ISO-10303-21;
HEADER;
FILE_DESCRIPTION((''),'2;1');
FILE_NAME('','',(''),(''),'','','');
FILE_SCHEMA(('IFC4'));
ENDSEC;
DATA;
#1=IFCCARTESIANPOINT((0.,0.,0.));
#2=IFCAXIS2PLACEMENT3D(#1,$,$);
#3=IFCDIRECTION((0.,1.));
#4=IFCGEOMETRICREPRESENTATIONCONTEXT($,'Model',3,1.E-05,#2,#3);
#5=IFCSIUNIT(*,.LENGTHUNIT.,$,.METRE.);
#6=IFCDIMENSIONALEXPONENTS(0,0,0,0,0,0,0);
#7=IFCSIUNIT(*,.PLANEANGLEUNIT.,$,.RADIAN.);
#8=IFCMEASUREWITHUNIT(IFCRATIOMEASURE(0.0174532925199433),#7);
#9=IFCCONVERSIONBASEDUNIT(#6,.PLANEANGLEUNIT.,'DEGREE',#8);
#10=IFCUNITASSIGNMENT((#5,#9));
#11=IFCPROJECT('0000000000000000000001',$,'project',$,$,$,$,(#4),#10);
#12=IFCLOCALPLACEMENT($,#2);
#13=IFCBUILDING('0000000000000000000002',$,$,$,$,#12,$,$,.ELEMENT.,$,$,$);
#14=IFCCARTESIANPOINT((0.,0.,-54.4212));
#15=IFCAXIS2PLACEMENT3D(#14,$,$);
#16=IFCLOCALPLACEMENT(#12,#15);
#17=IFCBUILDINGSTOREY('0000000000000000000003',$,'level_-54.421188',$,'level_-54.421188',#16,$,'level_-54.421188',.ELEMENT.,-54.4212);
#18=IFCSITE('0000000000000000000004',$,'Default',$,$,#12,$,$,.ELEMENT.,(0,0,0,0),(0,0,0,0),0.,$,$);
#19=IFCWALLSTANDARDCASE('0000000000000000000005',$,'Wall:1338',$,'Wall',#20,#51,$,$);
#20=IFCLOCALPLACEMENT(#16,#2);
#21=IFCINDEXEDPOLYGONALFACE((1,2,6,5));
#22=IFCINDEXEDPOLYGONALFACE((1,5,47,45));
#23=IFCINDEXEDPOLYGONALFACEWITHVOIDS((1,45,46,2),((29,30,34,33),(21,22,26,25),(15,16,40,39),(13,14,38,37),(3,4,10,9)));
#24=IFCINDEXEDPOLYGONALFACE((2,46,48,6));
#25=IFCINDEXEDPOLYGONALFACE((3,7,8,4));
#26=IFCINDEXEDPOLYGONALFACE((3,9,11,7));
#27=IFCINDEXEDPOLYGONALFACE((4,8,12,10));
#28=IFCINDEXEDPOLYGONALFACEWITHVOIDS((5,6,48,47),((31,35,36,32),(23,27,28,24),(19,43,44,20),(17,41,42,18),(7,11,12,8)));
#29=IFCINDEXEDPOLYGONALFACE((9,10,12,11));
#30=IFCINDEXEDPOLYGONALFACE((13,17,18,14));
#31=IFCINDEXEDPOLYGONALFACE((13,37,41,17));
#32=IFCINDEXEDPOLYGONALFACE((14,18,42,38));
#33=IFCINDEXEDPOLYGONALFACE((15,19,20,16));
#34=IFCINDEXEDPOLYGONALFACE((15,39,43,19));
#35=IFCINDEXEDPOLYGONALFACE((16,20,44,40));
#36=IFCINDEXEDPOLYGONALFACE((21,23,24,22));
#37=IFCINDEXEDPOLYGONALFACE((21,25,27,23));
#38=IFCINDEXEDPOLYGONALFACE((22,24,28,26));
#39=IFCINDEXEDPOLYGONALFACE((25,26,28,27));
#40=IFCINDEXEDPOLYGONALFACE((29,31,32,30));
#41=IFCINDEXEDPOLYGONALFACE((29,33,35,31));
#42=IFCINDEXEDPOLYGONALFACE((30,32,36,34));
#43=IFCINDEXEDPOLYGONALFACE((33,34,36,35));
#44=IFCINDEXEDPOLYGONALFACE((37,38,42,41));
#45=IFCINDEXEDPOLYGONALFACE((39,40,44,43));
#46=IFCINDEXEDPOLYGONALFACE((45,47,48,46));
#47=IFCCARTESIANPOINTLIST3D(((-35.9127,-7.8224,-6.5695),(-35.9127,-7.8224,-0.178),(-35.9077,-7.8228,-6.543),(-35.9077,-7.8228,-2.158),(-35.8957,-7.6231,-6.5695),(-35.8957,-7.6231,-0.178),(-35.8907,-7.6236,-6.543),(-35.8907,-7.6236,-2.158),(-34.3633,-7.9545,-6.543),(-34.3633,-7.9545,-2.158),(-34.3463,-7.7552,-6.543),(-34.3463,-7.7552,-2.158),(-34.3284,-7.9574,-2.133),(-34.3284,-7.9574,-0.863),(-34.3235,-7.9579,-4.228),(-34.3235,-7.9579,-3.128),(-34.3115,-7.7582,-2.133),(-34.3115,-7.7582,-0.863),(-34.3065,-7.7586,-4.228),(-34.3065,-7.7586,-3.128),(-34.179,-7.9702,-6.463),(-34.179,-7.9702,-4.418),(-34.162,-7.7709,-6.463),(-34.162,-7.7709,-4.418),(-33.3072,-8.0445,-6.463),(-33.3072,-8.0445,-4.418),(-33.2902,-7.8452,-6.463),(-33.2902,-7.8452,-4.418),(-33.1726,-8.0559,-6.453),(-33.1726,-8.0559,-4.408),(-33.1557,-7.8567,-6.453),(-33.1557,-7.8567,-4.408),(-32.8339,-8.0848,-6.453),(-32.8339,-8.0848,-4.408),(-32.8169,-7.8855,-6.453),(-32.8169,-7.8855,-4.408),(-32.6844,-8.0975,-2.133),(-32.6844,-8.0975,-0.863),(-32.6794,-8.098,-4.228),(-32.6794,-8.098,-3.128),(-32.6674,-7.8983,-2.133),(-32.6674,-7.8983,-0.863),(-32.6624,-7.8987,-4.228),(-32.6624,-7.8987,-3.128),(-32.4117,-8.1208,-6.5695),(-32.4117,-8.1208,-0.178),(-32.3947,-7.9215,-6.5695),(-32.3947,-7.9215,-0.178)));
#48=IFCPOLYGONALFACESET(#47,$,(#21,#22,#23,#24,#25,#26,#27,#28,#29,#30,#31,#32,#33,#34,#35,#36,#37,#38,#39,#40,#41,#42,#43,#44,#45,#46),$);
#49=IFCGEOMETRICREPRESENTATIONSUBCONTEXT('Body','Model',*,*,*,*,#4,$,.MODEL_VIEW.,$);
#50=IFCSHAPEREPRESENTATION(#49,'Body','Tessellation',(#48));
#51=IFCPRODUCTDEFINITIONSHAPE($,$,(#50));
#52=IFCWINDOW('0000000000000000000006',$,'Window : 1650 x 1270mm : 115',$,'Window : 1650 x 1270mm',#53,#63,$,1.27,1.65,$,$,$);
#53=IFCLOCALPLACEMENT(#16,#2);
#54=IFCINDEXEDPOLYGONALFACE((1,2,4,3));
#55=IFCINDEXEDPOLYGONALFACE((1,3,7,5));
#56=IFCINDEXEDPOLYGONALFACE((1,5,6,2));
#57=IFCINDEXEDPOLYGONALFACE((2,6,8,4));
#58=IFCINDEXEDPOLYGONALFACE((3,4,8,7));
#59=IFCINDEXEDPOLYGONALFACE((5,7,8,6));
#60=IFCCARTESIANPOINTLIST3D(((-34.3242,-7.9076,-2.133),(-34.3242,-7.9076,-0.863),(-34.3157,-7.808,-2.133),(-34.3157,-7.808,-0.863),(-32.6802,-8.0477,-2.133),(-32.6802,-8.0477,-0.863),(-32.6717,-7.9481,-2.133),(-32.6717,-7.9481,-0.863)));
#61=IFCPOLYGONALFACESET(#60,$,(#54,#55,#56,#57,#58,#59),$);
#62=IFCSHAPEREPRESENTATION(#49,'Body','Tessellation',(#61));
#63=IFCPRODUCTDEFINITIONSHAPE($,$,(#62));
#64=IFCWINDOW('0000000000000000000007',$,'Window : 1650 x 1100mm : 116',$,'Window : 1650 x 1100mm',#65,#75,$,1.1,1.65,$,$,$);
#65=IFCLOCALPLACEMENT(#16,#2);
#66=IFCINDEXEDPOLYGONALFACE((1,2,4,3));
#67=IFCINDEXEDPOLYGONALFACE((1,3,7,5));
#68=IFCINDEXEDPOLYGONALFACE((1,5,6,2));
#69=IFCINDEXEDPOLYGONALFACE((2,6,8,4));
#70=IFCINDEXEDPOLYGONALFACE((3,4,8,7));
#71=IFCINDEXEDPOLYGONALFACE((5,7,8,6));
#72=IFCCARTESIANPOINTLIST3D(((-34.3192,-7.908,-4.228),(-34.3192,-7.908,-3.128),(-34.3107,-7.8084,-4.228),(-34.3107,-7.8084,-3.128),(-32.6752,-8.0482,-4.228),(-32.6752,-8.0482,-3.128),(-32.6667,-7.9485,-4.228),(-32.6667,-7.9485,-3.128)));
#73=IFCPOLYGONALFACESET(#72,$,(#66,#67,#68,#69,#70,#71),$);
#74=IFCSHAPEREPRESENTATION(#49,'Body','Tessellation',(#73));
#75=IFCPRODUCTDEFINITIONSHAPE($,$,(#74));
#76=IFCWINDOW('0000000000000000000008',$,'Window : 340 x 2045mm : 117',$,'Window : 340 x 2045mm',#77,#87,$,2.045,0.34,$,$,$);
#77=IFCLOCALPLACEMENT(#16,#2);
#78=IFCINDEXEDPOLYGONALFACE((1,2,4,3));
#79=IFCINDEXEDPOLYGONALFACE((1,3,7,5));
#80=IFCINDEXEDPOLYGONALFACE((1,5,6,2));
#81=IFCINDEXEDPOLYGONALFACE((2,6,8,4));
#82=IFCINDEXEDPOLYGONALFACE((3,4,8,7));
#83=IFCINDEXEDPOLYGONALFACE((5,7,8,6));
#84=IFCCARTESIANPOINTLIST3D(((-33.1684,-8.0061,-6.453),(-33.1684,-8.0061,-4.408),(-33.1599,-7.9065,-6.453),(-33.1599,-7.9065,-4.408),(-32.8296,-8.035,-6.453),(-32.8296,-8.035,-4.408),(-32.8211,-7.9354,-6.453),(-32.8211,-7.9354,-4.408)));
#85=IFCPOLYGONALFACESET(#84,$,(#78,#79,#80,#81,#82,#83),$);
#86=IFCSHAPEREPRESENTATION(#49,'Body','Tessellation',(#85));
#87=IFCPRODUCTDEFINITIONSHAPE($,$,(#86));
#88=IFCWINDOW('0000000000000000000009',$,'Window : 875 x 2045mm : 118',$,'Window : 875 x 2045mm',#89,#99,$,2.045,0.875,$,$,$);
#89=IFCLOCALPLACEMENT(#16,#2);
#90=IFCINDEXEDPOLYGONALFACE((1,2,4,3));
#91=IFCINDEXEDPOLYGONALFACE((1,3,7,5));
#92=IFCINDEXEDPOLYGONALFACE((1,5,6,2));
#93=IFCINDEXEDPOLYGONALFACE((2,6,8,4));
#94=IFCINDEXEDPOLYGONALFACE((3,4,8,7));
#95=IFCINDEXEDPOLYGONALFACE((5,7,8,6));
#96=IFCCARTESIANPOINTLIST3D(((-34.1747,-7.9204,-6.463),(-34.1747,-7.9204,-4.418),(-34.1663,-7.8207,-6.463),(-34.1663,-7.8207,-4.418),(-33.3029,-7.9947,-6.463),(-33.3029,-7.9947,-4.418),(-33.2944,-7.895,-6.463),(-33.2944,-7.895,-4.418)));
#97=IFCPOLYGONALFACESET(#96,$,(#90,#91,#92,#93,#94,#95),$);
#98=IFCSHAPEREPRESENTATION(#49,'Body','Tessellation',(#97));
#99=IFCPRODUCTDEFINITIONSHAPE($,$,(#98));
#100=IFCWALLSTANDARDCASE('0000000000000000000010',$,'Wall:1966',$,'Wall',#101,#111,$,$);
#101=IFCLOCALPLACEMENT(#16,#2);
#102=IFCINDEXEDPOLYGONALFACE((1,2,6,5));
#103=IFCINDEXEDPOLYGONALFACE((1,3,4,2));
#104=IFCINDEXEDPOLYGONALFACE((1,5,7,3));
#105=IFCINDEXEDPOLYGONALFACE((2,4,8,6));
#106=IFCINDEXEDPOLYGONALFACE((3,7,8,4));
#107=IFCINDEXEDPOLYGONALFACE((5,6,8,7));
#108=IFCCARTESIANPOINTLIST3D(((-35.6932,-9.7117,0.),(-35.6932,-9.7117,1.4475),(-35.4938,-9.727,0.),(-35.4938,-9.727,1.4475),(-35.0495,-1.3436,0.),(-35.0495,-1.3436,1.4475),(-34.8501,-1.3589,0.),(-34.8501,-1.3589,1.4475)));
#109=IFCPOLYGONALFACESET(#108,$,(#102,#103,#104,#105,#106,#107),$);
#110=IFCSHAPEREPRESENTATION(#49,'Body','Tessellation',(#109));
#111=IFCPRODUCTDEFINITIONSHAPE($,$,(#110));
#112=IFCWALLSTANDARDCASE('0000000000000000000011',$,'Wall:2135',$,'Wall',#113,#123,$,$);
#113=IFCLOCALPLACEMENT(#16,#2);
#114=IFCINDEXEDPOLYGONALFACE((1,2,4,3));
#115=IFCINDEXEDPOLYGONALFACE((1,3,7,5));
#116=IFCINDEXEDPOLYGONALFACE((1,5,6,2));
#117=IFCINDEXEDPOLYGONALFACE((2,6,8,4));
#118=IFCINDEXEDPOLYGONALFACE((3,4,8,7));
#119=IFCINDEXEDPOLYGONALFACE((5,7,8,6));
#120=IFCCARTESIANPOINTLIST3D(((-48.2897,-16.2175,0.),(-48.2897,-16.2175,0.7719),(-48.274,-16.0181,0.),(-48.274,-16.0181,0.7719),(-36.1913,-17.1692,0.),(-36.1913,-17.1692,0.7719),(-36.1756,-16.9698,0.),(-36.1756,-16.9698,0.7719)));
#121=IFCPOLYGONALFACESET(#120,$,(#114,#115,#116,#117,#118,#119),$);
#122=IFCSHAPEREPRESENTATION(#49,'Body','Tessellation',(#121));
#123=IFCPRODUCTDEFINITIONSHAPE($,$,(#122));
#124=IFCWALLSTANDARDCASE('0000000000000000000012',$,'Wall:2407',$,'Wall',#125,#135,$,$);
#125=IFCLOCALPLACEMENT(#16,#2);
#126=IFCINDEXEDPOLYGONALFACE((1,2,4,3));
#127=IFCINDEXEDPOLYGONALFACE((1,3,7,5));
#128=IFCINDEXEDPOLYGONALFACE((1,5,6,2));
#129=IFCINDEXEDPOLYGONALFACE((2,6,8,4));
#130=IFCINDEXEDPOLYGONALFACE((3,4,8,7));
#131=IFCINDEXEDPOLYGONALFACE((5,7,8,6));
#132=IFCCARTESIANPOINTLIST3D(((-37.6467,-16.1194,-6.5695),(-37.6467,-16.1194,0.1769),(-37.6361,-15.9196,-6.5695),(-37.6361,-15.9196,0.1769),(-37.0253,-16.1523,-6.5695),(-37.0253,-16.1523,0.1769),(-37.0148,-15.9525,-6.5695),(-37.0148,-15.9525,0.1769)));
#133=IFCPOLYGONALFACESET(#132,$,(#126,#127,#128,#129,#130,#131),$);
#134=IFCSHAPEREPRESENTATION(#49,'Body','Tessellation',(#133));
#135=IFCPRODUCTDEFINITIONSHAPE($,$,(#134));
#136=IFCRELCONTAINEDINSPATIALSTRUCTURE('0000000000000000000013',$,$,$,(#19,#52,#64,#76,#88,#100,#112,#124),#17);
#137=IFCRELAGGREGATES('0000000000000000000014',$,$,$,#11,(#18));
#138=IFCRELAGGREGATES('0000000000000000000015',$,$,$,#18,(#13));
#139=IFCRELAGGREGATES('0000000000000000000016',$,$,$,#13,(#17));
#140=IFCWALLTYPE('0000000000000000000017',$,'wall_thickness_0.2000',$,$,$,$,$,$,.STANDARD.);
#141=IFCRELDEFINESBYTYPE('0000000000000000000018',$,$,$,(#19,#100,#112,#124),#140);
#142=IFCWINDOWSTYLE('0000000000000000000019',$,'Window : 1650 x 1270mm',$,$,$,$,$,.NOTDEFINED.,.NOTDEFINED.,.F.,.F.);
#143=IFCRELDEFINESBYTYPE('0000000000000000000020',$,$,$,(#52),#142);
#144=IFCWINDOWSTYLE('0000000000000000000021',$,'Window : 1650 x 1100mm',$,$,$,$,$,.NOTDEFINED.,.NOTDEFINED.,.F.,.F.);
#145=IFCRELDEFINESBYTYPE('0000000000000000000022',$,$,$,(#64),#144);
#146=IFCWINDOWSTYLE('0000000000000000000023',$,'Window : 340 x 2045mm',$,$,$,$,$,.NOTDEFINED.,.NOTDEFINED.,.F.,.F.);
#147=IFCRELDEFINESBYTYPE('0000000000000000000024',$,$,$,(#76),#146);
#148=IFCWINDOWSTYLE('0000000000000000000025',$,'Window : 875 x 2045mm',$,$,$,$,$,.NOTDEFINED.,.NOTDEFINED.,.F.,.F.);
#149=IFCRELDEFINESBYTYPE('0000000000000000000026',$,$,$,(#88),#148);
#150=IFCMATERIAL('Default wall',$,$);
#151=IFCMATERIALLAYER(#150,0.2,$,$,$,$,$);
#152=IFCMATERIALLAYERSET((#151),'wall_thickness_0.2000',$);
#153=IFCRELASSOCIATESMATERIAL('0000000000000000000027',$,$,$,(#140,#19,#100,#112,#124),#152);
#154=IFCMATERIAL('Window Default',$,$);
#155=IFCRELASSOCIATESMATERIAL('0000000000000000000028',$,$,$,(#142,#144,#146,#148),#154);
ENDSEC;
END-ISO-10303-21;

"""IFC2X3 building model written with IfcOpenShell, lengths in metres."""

from ifc_helpers import new_model, entity, si_unit, converted_unit, direction, frame, frame_2d, origin, origin_2d_with_axis, place, context, subcontext, project, spatial, polyline, rectangle, outline, extrude, source, transform, mapped, material, layer, layer_set, layer_usage, type_object, type_shapes, element, fill, save


model = new_model("IFC2X3")

# Units and contexts
model_context = context("Model", 3, precision=1e-05, world=origin(), true_north=direction((0.0, 1.0)))
body_context = subcontext(model_context, "Body", "Model", "MODEL_VIEW")
ifc_project = project(units=[si_unit("LENGTHUNIT", "METRE"), converted_unit("PLANEANGLEUNIT", "DEGREE", entity("IfcRatioMeasure", 0.0174532925199433), si_unit("PLANEANGLEUNIT", "RADIAN"), dimensions=[0, 0, 0, 0, 0, 0, 0])], contexts=[model_context])

# Site, building, storey
placement_1 = place(None, origin())
site = spatial("IfcSite", under=ifc_project, at=placement_1, Name="Default", CompositionType="ELEMENT", RefLatitude=(0, 0, 0, 0), RefLongitude=(0, 0, 0, 0), RefElevation=0.0)
building = spatial("IfcBuilding", under=site, at=placement_1, CompositionType="ELEMENT")
storey_placement = place(placement_1, frame((0.0, 0.0, -54.4212)))
storey = spatial("IfcBuildingStorey", under=building, at=storey_placement, Name="level_-54.421188", ObjectType="level_-54.421188", LongName="level_-54.421188", CompositionType="ELEMENT", Elevation=-54.4212)

# Shared definitions
ifc_material_1 = material(Name="Default wall")
ifc_layer = layer(ifc_material_1, 0.2)
ifc_layer_set = layer_set([ifc_layer], Name="wall_thickness_0.2000")
ifc_layer_usage = layer_usage(ifc_layer_set, "AXIS2", "POSITIVE", -0.1)
wall_type = type_object("IfcWallType", Name="wall_thickness_0.2000", PredefinedType="STANDARD", material=ifc_layer_set)

# Wall, openings, windows
ifc_material_2 = material(Name="Window Default")
placement_2 = place(placement_1, frame((0.0, 0.0, -60.9907)))
wall_1_placement = place(placement_2, frame((-32.4032, -8.0212, 0.0), z_axis=(0.0, 0.0, 1.0), x_axis=(-0.996388, 0.084916, 0.0)))
wall_1 = element("IfcWallStandardCase", 1, at=wall_1_placement, inside=storey, type_object=wall_type, material=ifc_layer_usage, Name="Wall:1338", ObjectType="Wall", context=body_context, shape_type="SweptSolid", body=[
    extrude(outline(polyline([(3.5137, -0.1), (3.5137, 0.1), (0.0, 0.1), (0.0, -0.1), (3.5137, -0.1)])), origin(), (0.0, 0.0, 1.0), 6.3915),
])
opening_1_placement = place(wall_1_placement, frame((1.9587, -0.1, 0.0265)))
element("IfcOpeningElement", 2, at=opening_1_placement, cuts=wall_1, ObjectType="Opening", context=body_context, shape_type="SweptSolid", body=[
    extrude(rectangle(XDim=1.55, YDim=4.385, at=frame_2d((2.1925, 0.775), x_axis=(0.0, 1.0))), frame((0.0, 0.0, 0.0), z_axis=(0.0, 1.0, 0.0), x_axis=(0.0, 0.0, 1.0)), (0.0, 0.0, 1.0), 0.2),
])
opening_2_placement = place(wall_1_placement, frame((0.2737, -0.1, 4.4365)))
opening_2 = element("IfcOpeningElement", 3, at=opening_2_placement, cuts=wall_1, ObjectType="Opening", context=body_context, shape_type="SweptSolid", body=[
    extrude(rectangle(XDim=1.65, YDim=1.27, at=frame_2d((0.635, 0.825), x_axis=(0.0, 1.0))), frame((0.0, 0.0, 0.0), z_axis=(0.0, 1.0, 0.0), x_axis=(0.0, 0.0, 1.0)), (0.0, 0.0, 1.0), 0.2),
])
opening_3_placement = place(wall_1_placement, frame((0.2687, -0.1, 2.3415)))
opening_3 = element("IfcOpeningElement", 4, at=opening_3_placement, cuts=wall_1, ObjectType="Opening", context=body_context, shape_type="SweptSolid", body=[
    extrude(rectangle(XDim=1.65, YDim=1.1, at=frame_2d((0.55, 0.825), x_axis=(0.0, 1.0))), frame((0.0, 0.0, 0.0), z_axis=(0.0, 1.0, 0.0), x_axis=(0.0, 0.0, 1.0)), (0.0, 0.0, 1.0), 0.2),
])
opening_4_placement = place(wall_1_placement, frame((0.4237, -0.1, 0.1165)))
opening_4 = element("IfcOpeningElement", 5, at=opening_4_placement, cuts=wall_1, ObjectType="Opening", context=body_context, shape_type="SweptSolid", body=[
    extrude(rectangle(XDim=0.34, YDim=2.045, at=frame_2d((1.0225, 0.17), x_axis=(0.0, 1.0))), frame((0.0, 0.0, 0.0), z_axis=(0.0, 1.0, 0.0), x_axis=(0.0, 0.0, 1.0)), (0.0, 0.0, 1.0), 0.2),
])
opening_5_placement = place(wall_1_placement, frame((0.8987, -0.1, 0.1065)))
opening_5 = element("IfcOpeningElement", 6, at=opening_5_placement, cuts=wall_1, ObjectType="Opening", context=body_context, shape_type="SweptSolid", body=[
    extrude(rectangle(XDim=0.875, YDim=2.045, at=frame_2d((1.0225, 0.4375), x_axis=(0.0, 1.0))), frame((0.0, 0.0, 0.0), z_axis=(0.0, 1.0, 0.0), x_axis=(0.0, 0.0, 1.0)), (0.0, 0.0, 1.0), 0.2),
])
window_style_1 = type_object("IfcWindowStyle", Name="Window : 1650 x 1270mm", ConstructionType="NOTDEFINED", OperationType="NOTDEFINED", ParameterTakesPrecedence=False, Sizeable=False, material=ifc_material_2)
shared_shape_1 = source(origin(), body_context, "Body", "SweptSolid", [
    extrude(rectangle(XDim=0.1, YDim=1.65, at=origin_2d_with_axis()), frame((0.825, 0.1, 0.0), z_axis=(0.0, 0.0, 1.0), x_axis=(0.0, 1.0, 0.0)), (0.0, 0.0, 1.0), 1.27),
])
type_shapes(window_style_1, [shared_shape_1])
window_1_placement = place(opening_2_placement, origin())
window_1 = element("IfcWindow", 7, at=window_1_placement, inside=storey, type_object=window_style_1, Name="Window : 1650 x 1270mm : 115", ObjectType="Window : 1650 x 1270mm", OverallHeight=1.27, OverallWidth=1.65, context=body_context, shape_type="MappedRepresentation", body=[
    mapped(shared_shape_1, transform((0.0, 0.0, 0.0), scale=1.0)),
])
fill(opening_2, window_1)
window_style_2 = type_object("IfcWindowStyle", Name="Window : 1650 x 1100mm", ConstructionType="NOTDEFINED", OperationType="NOTDEFINED", ParameterTakesPrecedence=False, Sizeable=False, material=ifc_material_2)
shared_shape_2 = source(origin(), body_context, "Body", "SweptSolid", [
    extrude(rectangle(XDim=0.1, YDim=1.65, at=origin_2d_with_axis()), frame((0.825, 0.1, 0.0), z_axis=(0.0, 0.0, 1.0), x_axis=(0.0, 1.0, 0.0)), (0.0, 0.0, 1.0), 1.1),
])
type_shapes(window_style_2, [shared_shape_2])
window_2_placement = place(opening_3_placement, origin())
window_2 = element("IfcWindow", 8, at=window_2_placement, inside=storey, type_object=window_style_2, Name="Window : 1650 x 1100mm : 116", ObjectType="Window : 1650 x 1100mm", OverallHeight=1.1, OverallWidth=1.65, context=body_context, shape_type="MappedRepresentation", body=[
    mapped(shared_shape_2, transform((0.0, 0.0, 0.0), scale=1.0)),
])
fill(opening_3, window_2)
window_style_3 = type_object("IfcWindowStyle", Name="Window : 340 x 2045mm", ConstructionType="NOTDEFINED", OperationType="NOTDEFINED", ParameterTakesPrecedence=False, Sizeable=False, material=ifc_material_2)
shared_shape_3 = source(origin(), body_context, "Body", "SweptSolid", [
    extrude(rectangle(XDim=0.1, YDim=0.34, at=origin_2d_with_axis()), frame((0.17, 0.1, 0.0), z_axis=(0.0, 0.0, 1.0), x_axis=(0.0, 1.0, 0.0)), (0.0, 0.0, 1.0), 2.045),
])
type_shapes(window_style_3, [shared_shape_3])
window_3_placement = place(opening_4_placement, origin())
window_3 = element("IfcWindow", 9, at=window_3_placement, inside=storey, type_object=window_style_3, Name="Window : 340 x 2045mm : 117", ObjectType="Window : 340 x 2045mm", OverallHeight=2.045, OverallWidth=0.34, context=body_context, shape_type="MappedRepresentation", body=[
    mapped(shared_shape_3, transform((0.0, 0.0, 0.0), scale=1.0)),
])
fill(opening_4, window_3)
window_style_4 = type_object("IfcWindowStyle", Name="Window : 875 x 2045mm", ConstructionType="NOTDEFINED", OperationType="NOTDEFINED", ParameterTakesPrecedence=False, Sizeable=False, material=ifc_material_2)
shared_shape_4 = source(origin(), body_context, "Body", "SweptSolid", [
    extrude(rectangle(XDim=0.1, YDim=0.875, at=origin_2d_with_axis()), frame((0.4375, 0.1, 0.0), z_axis=(0.0, 0.0, 1.0), x_axis=(0.0, 1.0, 0.0)), (0.0, 0.0, 1.0), 2.045),
])
type_shapes(window_style_4, [shared_shape_4])
window_4_placement = place(opening_5_placement, origin())
window_4 = element("IfcWindow", 10, at=window_4_placement, inside=storey, type_object=window_style_4, Name="Window : 875 x 2045mm : 118", ObjectType="Window : 875 x 2045mm", OverallHeight=2.045, OverallWidth=0.875, context=body_context, shape_type="MappedRepresentation", body=[
    mapped(shared_shape_4, transform((0.0, 0.0, 0.0), scale=1.0)),
])
fill(opening_5, window_4)

# Walls
wall_2_placement = place(storey_placement, frame((-35.5935, -9.7194, 0.0), z_axis=(0.0, 0.0, 1.0), x_axis=(0.0767, 0.997054, 0.0)))
element("IfcWallStandardCase", 11, at=wall_2_placement, inside=storey, type_object=wall_type, material=ifc_layer_usage, Name="Wall:1966", ObjectType="Wall", context=body_context, shape_type="SweptSolid", body=[
    extrude(outline(polyline([(8.3929, -0.1), (8.3929, 0.1), (0.0, 0.1), (0.0, -0.1), (8.3929, -0.1)])), origin(), (0.0, 0.0, 1.0), 1.4475),
])
wall_3_placement = place(storey_placement, frame((-48.2819, -16.1178, 0.0), z_axis=(0.0, 0.0, 1.0), x_axis=(0.996921, -0.078418, 0.0)))
element("IfcWallStandardCase", 12, at=wall_3_placement, inside=storey, type_object=wall_type, material=ifc_layer_usage, Name="Wall:2135", ObjectType="Wall", context=body_context, shape_type="SweptSolid", body=[
    extrude(outline(polyline([(12.1358, -0.1), (12.1358, 0.1), (0.0, 0.1), (0.0, -0.1), (12.1358, -0.1)])), origin(), (0.0, 0.0, 1.0), 0.7719),
])
placement_3 = place(placement_1, frame((0.0, 0.0, -60.9907)))
wall_4_placement = place(placement_3, frame((-37.0201, -16.0524, 0.0), z_axis=(0.0, 0.0, 1.0), x_axis=(-0.9986, 0.052896, 0.0)))
element("IfcWallStandardCase", 13, at=wall_4_placement, inside=storey, type_object=wall_type, material=ifc_layer_usage, Name="Wall:2407", ObjectType="Wall", context=body_context, shape_type="SweptSolid", body=[
    extrude(outline(polyline([(0.6222, -0.1), (0.6222, 0.1), (0.0, 0.1), (0.0, -0.1), (0.6222, -0.1)])), origin(), (0.0, 0.0, 1.0), 6.7464),
])

save(model, "model.ifc")
